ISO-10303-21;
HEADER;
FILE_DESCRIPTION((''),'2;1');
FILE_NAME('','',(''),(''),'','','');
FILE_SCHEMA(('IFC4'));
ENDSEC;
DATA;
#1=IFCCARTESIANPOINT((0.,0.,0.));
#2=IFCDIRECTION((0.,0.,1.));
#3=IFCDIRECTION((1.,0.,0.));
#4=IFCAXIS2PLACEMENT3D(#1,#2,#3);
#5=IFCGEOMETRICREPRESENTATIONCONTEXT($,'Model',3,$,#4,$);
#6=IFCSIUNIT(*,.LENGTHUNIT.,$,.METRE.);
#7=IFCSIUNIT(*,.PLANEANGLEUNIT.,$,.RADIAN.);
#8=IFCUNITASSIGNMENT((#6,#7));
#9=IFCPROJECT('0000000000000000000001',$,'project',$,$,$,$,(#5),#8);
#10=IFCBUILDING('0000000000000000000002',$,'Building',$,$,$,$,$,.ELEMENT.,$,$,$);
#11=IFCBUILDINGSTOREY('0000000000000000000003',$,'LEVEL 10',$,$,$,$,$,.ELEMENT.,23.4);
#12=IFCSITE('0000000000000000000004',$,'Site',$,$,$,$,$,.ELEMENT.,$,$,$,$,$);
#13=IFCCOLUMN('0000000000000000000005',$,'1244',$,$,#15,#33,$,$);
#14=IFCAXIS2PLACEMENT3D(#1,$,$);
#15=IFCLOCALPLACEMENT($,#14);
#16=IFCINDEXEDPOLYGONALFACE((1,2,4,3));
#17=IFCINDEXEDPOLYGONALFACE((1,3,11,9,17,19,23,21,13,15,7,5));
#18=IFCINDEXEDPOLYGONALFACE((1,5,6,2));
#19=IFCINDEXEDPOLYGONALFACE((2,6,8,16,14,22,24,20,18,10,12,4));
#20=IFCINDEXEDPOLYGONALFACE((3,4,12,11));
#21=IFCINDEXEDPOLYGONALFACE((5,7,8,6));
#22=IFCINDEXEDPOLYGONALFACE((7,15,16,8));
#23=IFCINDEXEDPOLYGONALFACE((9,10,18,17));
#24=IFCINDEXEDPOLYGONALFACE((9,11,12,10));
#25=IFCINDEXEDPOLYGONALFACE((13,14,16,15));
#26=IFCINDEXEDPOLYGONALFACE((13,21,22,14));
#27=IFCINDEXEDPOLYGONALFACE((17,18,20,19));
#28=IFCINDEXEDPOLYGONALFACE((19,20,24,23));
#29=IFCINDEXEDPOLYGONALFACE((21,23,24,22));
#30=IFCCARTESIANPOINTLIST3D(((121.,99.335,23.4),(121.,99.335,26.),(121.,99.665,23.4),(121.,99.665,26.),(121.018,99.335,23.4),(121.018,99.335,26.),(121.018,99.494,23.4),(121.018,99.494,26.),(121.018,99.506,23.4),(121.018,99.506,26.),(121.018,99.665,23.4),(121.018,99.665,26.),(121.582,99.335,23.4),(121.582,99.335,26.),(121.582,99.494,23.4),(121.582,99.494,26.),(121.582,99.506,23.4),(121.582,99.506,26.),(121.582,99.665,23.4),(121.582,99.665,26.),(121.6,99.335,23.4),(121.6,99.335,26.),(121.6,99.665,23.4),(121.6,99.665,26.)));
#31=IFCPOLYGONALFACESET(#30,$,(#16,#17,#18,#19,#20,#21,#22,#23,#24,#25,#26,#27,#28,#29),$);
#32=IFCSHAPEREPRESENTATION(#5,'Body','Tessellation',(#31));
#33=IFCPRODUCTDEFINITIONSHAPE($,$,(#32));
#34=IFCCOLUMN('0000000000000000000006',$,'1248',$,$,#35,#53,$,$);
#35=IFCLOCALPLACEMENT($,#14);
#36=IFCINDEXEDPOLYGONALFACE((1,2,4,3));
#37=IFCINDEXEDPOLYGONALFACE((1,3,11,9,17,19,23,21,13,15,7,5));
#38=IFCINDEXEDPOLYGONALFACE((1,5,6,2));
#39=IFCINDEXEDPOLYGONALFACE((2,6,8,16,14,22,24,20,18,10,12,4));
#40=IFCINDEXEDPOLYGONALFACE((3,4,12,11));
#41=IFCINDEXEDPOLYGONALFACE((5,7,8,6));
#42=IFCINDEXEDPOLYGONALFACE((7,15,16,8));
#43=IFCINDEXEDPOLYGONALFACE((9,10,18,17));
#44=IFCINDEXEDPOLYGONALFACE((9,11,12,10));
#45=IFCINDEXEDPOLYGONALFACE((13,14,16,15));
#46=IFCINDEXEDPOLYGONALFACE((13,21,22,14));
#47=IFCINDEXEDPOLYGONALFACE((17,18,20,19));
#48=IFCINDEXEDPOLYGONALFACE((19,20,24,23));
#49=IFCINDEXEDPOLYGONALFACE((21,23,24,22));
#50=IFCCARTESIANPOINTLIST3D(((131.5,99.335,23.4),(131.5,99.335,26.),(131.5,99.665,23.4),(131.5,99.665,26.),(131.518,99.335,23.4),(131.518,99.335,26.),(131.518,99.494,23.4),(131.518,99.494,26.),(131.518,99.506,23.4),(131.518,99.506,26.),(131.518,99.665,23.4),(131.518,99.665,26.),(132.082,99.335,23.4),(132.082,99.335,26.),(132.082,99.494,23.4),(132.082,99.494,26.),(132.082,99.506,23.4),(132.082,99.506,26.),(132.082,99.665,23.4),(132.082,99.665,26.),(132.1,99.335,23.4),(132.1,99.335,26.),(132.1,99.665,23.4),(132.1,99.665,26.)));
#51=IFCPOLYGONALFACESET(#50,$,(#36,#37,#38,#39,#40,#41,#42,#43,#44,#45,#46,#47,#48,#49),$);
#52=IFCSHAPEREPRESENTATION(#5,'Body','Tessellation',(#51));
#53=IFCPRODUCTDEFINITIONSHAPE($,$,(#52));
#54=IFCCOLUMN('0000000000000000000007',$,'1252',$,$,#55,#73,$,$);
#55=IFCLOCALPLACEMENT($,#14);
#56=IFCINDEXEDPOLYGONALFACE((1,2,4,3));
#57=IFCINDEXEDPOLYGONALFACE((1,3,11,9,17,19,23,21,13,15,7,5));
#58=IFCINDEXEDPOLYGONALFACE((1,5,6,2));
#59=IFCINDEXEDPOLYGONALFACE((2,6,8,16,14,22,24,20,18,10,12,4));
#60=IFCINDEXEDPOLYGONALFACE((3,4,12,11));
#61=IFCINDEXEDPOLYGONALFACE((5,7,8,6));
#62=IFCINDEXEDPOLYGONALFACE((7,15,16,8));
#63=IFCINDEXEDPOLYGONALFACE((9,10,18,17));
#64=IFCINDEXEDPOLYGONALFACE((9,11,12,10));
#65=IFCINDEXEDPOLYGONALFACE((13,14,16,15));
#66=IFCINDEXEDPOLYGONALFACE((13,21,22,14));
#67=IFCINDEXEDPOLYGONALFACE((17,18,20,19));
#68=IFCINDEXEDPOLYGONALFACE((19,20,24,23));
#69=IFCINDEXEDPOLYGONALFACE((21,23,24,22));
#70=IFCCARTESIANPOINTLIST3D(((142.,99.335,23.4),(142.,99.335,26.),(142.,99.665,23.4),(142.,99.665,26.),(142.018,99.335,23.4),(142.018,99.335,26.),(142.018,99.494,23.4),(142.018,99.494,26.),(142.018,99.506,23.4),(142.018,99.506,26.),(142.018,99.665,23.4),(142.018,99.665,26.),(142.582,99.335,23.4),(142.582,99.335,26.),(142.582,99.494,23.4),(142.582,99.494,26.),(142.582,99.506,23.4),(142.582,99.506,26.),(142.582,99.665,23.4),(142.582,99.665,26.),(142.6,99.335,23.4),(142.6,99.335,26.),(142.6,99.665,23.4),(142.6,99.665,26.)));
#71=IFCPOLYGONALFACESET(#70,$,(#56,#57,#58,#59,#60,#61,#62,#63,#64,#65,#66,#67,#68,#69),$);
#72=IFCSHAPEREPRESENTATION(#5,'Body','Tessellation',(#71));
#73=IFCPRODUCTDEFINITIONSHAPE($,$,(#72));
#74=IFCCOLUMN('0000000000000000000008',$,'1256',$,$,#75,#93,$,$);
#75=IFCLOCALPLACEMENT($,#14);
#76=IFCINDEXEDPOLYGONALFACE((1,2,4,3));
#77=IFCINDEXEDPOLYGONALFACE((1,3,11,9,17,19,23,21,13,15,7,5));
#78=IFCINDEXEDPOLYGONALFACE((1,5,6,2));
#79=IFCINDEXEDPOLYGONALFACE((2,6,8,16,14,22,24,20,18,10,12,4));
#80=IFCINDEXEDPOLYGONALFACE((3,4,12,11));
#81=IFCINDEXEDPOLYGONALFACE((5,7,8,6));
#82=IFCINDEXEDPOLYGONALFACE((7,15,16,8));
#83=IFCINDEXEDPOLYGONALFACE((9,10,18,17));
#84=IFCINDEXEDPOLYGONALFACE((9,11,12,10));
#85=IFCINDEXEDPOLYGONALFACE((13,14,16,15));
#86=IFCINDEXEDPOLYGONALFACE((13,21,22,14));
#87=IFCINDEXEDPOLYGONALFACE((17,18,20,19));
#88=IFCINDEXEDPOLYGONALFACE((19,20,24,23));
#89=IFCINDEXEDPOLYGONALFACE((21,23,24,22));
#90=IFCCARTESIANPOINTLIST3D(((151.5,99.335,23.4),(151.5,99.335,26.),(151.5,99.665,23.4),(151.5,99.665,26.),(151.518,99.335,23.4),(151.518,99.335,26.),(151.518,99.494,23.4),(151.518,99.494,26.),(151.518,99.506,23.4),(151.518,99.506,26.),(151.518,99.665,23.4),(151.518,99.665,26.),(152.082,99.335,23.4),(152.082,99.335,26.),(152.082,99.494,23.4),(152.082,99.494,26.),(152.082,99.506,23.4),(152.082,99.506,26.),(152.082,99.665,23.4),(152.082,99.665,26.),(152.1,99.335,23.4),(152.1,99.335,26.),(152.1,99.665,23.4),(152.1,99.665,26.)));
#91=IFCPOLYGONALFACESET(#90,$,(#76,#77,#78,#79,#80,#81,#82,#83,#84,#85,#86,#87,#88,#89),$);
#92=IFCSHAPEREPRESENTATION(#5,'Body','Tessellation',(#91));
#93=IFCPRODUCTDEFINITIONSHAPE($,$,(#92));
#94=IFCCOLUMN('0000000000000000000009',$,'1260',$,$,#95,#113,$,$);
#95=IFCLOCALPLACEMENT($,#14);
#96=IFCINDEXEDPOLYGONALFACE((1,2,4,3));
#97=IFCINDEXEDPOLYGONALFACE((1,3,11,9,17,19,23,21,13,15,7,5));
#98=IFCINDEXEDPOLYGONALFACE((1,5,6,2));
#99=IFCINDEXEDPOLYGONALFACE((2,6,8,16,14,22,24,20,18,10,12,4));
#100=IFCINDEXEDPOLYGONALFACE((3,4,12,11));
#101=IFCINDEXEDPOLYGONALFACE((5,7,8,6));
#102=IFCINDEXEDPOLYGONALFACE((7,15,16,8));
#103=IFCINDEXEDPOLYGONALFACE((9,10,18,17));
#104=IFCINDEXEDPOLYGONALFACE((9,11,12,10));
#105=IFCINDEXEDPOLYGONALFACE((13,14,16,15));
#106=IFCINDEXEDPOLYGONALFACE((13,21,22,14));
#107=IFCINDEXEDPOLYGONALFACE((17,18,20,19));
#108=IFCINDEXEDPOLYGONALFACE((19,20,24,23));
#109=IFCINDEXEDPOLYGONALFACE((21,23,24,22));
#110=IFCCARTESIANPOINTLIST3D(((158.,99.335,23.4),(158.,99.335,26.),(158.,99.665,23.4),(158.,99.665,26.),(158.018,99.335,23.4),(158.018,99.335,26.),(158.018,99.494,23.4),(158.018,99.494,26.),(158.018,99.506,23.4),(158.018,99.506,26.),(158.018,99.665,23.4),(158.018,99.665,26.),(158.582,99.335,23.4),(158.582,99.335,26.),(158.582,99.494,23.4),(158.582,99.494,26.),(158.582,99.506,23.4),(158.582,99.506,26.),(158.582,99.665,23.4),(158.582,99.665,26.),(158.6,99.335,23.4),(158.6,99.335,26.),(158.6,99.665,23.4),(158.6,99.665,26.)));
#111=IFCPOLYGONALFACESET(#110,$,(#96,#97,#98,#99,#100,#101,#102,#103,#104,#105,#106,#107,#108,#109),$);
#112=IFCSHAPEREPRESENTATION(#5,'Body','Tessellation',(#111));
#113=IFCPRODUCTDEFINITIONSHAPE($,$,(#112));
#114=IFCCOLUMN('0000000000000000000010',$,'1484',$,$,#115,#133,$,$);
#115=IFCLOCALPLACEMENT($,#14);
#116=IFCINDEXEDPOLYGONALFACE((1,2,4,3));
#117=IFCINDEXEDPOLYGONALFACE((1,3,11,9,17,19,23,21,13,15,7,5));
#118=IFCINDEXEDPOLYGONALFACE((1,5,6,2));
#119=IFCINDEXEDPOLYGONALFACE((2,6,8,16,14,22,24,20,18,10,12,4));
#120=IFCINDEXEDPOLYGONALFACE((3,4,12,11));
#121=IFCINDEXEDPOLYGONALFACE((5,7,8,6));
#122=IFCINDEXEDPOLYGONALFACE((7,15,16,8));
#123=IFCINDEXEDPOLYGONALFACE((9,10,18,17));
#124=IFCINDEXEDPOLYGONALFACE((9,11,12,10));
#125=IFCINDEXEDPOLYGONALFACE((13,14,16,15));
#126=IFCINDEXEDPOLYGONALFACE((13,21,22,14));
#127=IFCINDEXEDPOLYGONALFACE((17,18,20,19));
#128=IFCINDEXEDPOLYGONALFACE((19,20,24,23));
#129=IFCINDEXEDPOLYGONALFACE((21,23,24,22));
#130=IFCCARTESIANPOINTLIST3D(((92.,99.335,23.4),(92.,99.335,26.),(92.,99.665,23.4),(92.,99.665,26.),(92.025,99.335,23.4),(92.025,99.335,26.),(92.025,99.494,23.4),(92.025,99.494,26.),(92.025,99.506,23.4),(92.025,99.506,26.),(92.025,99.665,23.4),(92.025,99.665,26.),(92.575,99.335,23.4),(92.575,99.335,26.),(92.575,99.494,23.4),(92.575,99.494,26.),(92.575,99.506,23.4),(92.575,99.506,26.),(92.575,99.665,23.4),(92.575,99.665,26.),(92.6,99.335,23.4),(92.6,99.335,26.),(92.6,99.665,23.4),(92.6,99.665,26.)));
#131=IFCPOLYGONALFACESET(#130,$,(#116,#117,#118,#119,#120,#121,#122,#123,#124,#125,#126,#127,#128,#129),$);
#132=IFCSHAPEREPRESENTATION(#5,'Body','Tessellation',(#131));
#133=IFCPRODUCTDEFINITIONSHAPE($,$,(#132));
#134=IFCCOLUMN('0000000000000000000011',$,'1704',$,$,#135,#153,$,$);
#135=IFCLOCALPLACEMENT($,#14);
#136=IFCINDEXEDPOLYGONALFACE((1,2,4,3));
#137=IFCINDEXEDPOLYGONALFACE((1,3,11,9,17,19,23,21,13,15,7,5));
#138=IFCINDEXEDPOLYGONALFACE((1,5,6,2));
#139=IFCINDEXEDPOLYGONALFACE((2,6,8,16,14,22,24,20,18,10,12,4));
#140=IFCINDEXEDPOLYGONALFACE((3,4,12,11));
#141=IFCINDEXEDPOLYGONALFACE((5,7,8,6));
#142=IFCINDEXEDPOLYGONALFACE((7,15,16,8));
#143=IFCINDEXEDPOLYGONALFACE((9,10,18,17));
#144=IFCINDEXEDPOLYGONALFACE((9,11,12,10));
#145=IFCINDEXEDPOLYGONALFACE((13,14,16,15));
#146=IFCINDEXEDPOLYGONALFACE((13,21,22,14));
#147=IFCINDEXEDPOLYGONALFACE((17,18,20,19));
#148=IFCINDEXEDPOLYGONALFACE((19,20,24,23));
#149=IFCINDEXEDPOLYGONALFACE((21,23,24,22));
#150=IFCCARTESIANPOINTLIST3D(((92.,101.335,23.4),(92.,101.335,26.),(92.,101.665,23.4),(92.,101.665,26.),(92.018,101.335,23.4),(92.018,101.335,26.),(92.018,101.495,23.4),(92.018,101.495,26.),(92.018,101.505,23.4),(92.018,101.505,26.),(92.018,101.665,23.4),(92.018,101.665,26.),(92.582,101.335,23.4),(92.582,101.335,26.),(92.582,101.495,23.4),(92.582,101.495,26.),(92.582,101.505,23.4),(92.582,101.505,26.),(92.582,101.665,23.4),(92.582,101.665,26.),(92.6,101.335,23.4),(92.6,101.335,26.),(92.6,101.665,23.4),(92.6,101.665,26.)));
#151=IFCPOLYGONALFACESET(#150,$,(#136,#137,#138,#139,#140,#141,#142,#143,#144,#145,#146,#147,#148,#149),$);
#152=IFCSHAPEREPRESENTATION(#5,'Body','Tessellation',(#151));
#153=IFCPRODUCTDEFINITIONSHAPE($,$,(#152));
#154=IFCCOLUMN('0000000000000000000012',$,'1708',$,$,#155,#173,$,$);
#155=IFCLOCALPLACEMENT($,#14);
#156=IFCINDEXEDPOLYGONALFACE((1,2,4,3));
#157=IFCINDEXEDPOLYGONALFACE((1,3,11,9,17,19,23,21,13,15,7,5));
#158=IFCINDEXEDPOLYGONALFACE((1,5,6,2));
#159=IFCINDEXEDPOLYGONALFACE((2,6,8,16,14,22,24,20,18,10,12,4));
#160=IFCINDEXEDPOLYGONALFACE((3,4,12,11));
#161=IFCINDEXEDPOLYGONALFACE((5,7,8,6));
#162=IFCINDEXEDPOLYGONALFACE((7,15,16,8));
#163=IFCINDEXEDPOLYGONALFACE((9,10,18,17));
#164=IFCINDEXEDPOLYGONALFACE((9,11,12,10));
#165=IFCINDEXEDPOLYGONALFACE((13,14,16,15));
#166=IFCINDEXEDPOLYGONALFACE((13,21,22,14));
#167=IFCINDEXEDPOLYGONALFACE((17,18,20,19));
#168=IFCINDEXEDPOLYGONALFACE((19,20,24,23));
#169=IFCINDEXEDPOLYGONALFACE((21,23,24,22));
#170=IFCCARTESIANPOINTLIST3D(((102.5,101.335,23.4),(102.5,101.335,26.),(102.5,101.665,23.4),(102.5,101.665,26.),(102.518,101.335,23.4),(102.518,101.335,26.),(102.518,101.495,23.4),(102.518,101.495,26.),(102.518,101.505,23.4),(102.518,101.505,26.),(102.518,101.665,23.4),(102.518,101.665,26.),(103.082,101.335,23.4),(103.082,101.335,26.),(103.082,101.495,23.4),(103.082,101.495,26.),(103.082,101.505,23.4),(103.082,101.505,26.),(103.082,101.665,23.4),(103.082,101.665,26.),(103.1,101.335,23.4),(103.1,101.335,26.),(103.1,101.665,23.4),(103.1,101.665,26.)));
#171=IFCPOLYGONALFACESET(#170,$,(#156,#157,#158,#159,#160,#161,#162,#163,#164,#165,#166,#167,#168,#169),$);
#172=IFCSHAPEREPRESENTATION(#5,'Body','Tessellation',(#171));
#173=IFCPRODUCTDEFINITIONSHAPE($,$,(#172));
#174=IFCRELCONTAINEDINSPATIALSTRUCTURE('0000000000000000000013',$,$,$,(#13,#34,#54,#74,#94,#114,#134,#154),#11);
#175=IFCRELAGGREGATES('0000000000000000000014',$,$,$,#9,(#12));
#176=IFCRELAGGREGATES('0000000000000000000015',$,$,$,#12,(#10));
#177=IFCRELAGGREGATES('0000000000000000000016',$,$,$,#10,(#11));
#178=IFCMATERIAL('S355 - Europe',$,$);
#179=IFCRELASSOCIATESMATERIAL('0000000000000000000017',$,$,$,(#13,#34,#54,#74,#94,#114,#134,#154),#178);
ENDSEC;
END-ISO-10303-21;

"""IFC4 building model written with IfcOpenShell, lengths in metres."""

from ifc_helpers import new_model, si_unit, frame, origin_with_axes, origin_2d_with_axis, place, context, project, spatial, i_section, extrude, material, material_profile, profile_set, profile_usage, element, save


model = new_model("IFC4")

# Units and contexts
model_context = context("Model", 3, world=origin_with_axes())
ifc_project = project(units=[si_unit("LENGTHUNIT", "METRE"), si_unit("PLANEANGLEUNIT", "RADIAN")], contexts=[model_context])

# Site, building, storey
site = spatial("IfcSite", under=ifc_project, Name="Site", CompositionType="ELEMENT")
building = spatial("IfcBuilding", under=site, Name="Building", CompositionType="ELEMENT")
storey = spatial("IfcBuildingStorey", under=building, Name="LEVEL 10", CompositionType="ELEMENT", Elevation=23.4)

# Columns
ifc_material = material(Name="S355 - Europe")
ifc_material_profile_1 = material_profile(ifc_material, i_section(OverallWidth=0.33, OverallDepth=0.6, WebThickness=0.012, FlangeThickness=0.018, at=origin_2d_with_axis()))
ifc_profile_set_1 = profile_set([ifc_material_profile_1])
ifc_profile_usage_1 = profile_usage(ifc_profile_set_1, cardinal=10)
column_1_placement = place(None, frame((121.3, 99.5, 23.4), z_axis=(0.0, 0.0, 1.0), x_axis=(0.0, -1.0, 0.0)))
element("IfcColumn", 1, at=column_1_placement, inside=storey, material=ifc_profile_usage_1, Name="1244", context=model_context, shape_type="SweptSolid", body=[
    extrude(i_section(OverallWidth=0.33, OverallDepth=0.6, WebThickness=0.012, FlangeThickness=0.018, at=origin_2d_with_axis()), origin_with_axes(), (0.0, 0.0, 1.0), 2.6),
])
ifc_material_profile_2 = material_profile(ifc_material, i_section(OverallWidth=0.33, OverallDepth=0.6, WebThickness=0.012, FlangeThickness=0.018, at=origin_2d_with_axis()))
ifc_profile_set_2 = profile_set([ifc_material_profile_2])
ifc_profile_usage_2 = profile_usage(ifc_profile_set_2, cardinal=10)
column_2_placement = place(None, frame((131.8, 99.5, 23.4), z_axis=(0.0, 0.0, 1.0), x_axis=(0.0, -1.0, 0.0)))
element("IfcColumn", 2, at=column_2_placement, inside=storey, material=ifc_profile_usage_2, Name="1248", context=model_context, shape_type="SweptSolid", body=[
    extrude(i_section(OverallWidth=0.33, OverallDepth=0.6, WebThickness=0.012, FlangeThickness=0.018, at=origin_2d_with_axis()), origin_with_axes(), (0.0, 0.0, 1.0), 2.6),
])
ifc_material_profile_3 = material_profile(ifc_material, i_section(OverallWidth=0.33, OverallDepth=0.6, WebThickness=0.012, FlangeThickness=0.018, at=origin_2d_with_axis()))
ifc_profile_set_3 = profile_set([ifc_material_profile_3])
ifc_profile_usage_3 = profile_usage(ifc_profile_set_3, cardinal=10)
column_3_placement = place(None, frame((142.3, 99.5, 23.4), z_axis=(0.0, 0.0, 1.0), x_axis=(0.0, -1.0, 0.0)))
element("IfcColumn", 3, at=column_3_placement, inside=storey, material=ifc_profile_usage_3, Name="1252", context=model_context, shape_type="SweptSolid", body=[
    extrude(i_section(OverallWidth=0.33, OverallDepth=0.6, WebThickness=0.012, FlangeThickness=0.018, at=origin_2d_with_axis()), origin_with_axes(), (0.0, 0.0, 1.0), 2.6),
])
ifc_material_profile_4 = material_profile(ifc_material, i_section(OverallWidth=0.33, OverallDepth=0.6, WebThickness=0.012, FlangeThickness=0.018, at=origin_2d_with_axis()))
ifc_profile_set_4 = profile_set([ifc_material_profile_4])
ifc_profile_usage_4 = profile_usage(ifc_profile_set_4, cardinal=10)
column_4_placement = place(None, frame((151.8, 99.5, 23.4), z_axis=(0.0, 0.0, 1.0), x_axis=(0.0, -1.0, 0.0)))
element("IfcColumn", 4, at=column_4_placement, inside=storey, material=ifc_profile_usage_4, Name="1256", context=model_context, shape_type="SweptSolid", body=[
    extrude(i_section(OverallWidth=0.33, OverallDepth=0.6, WebThickness=0.012, FlangeThickness=0.018, at=origin_2d_with_axis()), origin_with_axes(), (0.0, 0.0, 1.0), 2.6),
])
ifc_material_profile_5 = material_profile(ifc_material, i_section(OverallWidth=0.33, OverallDepth=0.6, WebThickness=0.012, FlangeThickness=0.018, at=origin_2d_with_axis()))
ifc_profile_set_5 = profile_set([ifc_material_profile_5])
ifc_profile_usage_5 = profile_usage(ifc_profile_set_5, cardinal=10)
column_5_placement = place(None, frame((158.3, 99.5, 23.4), z_axis=(0.0, 0.0, 1.0), x_axis=(0.0, -1.0, 0.0)))
element("IfcColumn", 5, at=column_5_placement, inside=storey, material=ifc_profile_usage_5, Name="1260", context=model_context, shape_type="SweptSolid", body=[
    extrude(i_section(OverallWidth=0.33, OverallDepth=0.6, WebThickness=0.012, FlangeThickness=0.018, at=origin_2d_with_axis()), origin_with_axes(), (0.0, 0.0, 1.0), 2.6),
])
ifc_material_profile_6 = material_profile(ifc_material, i_section(OverallWidth=0.33, OverallDepth=0.6, WebThickness=0.012, FlangeThickness=0.025, at=origin_2d_with_axis()))
ifc_profile_set_6 = profile_set([ifc_material_profile_6])
ifc_profile_usage_6 = profile_usage(ifc_profile_set_6, cardinal=10)
column_6_placement = place(None, frame((92.3, 99.5, 23.4), z_axis=(0.0, 0.0, 1.0), x_axis=(0.0, -1.0, 0.0)))
element("IfcColumn", 6, at=column_6_placement, inside=storey, material=ifc_profile_usage_6, Name="1484", context=model_context, shape_type="SweptSolid", body=[
    extrude(i_section(OverallWidth=0.33, OverallDepth=0.6, WebThickness=0.012, FlangeThickness=0.025, at=origin_2d_with_axis()), origin_with_axes(), (0.0, 0.0, 1.0), 2.6),
])
ifc_material_profile_7 = material_profile(ifc_material, i_section(OverallWidth=0.33, OverallDepth=0.6, WebThickness=0.01, FlangeThickness=0.018, at=origin_2d_with_axis()))
ifc_profile_set_7 = profile_set([ifc_material_profile_7])
ifc_profile_usage_7 = profile_usage(ifc_profile_set_7, cardinal=10)
column_7_placement = place(None, frame((92.3, 101.5, 23.4), z_axis=(0.0, 0.0, 1.0), x_axis=(0.0, -1.0, 0.0)))
element("IfcColumn", 7, at=column_7_placement, inside=storey, material=ifc_profile_usage_7, Name="1704", context=model_context, shape_type="SweptSolid", body=[
    extrude(i_section(OverallWidth=0.33, OverallDepth=0.6, WebThickness=0.01, FlangeThickness=0.018, at=origin_2d_with_axis()), origin_with_axes(), (0.0, 0.0, 1.0), 2.6),
])
ifc_material_profile_8 = material_profile(ifc_material, i_section(OverallWidth=0.33, OverallDepth=0.6, WebThickness=0.01, FlangeThickness=0.018, at=origin_2d_with_axis()))
ifc_profile_set_8 = profile_set([ifc_material_profile_8])
ifc_profile_usage_8 = profile_usage(ifc_profile_set_8, cardinal=10)
column_8_placement = place(None, frame((102.8, 101.5, 23.4), z_axis=(0.0, 0.0, 1.0), x_axis=(0.0, -1.0, 0.0)))
element("IfcColumn", 8, at=column_8_placement, inside=storey, material=ifc_profile_usage_8, Name="1708", context=model_context, shape_type="SweptSolid", body=[
    extrude(i_section(OverallWidth=0.33, OverallDepth=0.6, WebThickness=0.01, FlangeThickness=0.018, at=origin_2d_with_axis()), origin_with_axes(), (0.0, 0.0, 1.0), 2.6),
])

save(model, "model.ifc")
